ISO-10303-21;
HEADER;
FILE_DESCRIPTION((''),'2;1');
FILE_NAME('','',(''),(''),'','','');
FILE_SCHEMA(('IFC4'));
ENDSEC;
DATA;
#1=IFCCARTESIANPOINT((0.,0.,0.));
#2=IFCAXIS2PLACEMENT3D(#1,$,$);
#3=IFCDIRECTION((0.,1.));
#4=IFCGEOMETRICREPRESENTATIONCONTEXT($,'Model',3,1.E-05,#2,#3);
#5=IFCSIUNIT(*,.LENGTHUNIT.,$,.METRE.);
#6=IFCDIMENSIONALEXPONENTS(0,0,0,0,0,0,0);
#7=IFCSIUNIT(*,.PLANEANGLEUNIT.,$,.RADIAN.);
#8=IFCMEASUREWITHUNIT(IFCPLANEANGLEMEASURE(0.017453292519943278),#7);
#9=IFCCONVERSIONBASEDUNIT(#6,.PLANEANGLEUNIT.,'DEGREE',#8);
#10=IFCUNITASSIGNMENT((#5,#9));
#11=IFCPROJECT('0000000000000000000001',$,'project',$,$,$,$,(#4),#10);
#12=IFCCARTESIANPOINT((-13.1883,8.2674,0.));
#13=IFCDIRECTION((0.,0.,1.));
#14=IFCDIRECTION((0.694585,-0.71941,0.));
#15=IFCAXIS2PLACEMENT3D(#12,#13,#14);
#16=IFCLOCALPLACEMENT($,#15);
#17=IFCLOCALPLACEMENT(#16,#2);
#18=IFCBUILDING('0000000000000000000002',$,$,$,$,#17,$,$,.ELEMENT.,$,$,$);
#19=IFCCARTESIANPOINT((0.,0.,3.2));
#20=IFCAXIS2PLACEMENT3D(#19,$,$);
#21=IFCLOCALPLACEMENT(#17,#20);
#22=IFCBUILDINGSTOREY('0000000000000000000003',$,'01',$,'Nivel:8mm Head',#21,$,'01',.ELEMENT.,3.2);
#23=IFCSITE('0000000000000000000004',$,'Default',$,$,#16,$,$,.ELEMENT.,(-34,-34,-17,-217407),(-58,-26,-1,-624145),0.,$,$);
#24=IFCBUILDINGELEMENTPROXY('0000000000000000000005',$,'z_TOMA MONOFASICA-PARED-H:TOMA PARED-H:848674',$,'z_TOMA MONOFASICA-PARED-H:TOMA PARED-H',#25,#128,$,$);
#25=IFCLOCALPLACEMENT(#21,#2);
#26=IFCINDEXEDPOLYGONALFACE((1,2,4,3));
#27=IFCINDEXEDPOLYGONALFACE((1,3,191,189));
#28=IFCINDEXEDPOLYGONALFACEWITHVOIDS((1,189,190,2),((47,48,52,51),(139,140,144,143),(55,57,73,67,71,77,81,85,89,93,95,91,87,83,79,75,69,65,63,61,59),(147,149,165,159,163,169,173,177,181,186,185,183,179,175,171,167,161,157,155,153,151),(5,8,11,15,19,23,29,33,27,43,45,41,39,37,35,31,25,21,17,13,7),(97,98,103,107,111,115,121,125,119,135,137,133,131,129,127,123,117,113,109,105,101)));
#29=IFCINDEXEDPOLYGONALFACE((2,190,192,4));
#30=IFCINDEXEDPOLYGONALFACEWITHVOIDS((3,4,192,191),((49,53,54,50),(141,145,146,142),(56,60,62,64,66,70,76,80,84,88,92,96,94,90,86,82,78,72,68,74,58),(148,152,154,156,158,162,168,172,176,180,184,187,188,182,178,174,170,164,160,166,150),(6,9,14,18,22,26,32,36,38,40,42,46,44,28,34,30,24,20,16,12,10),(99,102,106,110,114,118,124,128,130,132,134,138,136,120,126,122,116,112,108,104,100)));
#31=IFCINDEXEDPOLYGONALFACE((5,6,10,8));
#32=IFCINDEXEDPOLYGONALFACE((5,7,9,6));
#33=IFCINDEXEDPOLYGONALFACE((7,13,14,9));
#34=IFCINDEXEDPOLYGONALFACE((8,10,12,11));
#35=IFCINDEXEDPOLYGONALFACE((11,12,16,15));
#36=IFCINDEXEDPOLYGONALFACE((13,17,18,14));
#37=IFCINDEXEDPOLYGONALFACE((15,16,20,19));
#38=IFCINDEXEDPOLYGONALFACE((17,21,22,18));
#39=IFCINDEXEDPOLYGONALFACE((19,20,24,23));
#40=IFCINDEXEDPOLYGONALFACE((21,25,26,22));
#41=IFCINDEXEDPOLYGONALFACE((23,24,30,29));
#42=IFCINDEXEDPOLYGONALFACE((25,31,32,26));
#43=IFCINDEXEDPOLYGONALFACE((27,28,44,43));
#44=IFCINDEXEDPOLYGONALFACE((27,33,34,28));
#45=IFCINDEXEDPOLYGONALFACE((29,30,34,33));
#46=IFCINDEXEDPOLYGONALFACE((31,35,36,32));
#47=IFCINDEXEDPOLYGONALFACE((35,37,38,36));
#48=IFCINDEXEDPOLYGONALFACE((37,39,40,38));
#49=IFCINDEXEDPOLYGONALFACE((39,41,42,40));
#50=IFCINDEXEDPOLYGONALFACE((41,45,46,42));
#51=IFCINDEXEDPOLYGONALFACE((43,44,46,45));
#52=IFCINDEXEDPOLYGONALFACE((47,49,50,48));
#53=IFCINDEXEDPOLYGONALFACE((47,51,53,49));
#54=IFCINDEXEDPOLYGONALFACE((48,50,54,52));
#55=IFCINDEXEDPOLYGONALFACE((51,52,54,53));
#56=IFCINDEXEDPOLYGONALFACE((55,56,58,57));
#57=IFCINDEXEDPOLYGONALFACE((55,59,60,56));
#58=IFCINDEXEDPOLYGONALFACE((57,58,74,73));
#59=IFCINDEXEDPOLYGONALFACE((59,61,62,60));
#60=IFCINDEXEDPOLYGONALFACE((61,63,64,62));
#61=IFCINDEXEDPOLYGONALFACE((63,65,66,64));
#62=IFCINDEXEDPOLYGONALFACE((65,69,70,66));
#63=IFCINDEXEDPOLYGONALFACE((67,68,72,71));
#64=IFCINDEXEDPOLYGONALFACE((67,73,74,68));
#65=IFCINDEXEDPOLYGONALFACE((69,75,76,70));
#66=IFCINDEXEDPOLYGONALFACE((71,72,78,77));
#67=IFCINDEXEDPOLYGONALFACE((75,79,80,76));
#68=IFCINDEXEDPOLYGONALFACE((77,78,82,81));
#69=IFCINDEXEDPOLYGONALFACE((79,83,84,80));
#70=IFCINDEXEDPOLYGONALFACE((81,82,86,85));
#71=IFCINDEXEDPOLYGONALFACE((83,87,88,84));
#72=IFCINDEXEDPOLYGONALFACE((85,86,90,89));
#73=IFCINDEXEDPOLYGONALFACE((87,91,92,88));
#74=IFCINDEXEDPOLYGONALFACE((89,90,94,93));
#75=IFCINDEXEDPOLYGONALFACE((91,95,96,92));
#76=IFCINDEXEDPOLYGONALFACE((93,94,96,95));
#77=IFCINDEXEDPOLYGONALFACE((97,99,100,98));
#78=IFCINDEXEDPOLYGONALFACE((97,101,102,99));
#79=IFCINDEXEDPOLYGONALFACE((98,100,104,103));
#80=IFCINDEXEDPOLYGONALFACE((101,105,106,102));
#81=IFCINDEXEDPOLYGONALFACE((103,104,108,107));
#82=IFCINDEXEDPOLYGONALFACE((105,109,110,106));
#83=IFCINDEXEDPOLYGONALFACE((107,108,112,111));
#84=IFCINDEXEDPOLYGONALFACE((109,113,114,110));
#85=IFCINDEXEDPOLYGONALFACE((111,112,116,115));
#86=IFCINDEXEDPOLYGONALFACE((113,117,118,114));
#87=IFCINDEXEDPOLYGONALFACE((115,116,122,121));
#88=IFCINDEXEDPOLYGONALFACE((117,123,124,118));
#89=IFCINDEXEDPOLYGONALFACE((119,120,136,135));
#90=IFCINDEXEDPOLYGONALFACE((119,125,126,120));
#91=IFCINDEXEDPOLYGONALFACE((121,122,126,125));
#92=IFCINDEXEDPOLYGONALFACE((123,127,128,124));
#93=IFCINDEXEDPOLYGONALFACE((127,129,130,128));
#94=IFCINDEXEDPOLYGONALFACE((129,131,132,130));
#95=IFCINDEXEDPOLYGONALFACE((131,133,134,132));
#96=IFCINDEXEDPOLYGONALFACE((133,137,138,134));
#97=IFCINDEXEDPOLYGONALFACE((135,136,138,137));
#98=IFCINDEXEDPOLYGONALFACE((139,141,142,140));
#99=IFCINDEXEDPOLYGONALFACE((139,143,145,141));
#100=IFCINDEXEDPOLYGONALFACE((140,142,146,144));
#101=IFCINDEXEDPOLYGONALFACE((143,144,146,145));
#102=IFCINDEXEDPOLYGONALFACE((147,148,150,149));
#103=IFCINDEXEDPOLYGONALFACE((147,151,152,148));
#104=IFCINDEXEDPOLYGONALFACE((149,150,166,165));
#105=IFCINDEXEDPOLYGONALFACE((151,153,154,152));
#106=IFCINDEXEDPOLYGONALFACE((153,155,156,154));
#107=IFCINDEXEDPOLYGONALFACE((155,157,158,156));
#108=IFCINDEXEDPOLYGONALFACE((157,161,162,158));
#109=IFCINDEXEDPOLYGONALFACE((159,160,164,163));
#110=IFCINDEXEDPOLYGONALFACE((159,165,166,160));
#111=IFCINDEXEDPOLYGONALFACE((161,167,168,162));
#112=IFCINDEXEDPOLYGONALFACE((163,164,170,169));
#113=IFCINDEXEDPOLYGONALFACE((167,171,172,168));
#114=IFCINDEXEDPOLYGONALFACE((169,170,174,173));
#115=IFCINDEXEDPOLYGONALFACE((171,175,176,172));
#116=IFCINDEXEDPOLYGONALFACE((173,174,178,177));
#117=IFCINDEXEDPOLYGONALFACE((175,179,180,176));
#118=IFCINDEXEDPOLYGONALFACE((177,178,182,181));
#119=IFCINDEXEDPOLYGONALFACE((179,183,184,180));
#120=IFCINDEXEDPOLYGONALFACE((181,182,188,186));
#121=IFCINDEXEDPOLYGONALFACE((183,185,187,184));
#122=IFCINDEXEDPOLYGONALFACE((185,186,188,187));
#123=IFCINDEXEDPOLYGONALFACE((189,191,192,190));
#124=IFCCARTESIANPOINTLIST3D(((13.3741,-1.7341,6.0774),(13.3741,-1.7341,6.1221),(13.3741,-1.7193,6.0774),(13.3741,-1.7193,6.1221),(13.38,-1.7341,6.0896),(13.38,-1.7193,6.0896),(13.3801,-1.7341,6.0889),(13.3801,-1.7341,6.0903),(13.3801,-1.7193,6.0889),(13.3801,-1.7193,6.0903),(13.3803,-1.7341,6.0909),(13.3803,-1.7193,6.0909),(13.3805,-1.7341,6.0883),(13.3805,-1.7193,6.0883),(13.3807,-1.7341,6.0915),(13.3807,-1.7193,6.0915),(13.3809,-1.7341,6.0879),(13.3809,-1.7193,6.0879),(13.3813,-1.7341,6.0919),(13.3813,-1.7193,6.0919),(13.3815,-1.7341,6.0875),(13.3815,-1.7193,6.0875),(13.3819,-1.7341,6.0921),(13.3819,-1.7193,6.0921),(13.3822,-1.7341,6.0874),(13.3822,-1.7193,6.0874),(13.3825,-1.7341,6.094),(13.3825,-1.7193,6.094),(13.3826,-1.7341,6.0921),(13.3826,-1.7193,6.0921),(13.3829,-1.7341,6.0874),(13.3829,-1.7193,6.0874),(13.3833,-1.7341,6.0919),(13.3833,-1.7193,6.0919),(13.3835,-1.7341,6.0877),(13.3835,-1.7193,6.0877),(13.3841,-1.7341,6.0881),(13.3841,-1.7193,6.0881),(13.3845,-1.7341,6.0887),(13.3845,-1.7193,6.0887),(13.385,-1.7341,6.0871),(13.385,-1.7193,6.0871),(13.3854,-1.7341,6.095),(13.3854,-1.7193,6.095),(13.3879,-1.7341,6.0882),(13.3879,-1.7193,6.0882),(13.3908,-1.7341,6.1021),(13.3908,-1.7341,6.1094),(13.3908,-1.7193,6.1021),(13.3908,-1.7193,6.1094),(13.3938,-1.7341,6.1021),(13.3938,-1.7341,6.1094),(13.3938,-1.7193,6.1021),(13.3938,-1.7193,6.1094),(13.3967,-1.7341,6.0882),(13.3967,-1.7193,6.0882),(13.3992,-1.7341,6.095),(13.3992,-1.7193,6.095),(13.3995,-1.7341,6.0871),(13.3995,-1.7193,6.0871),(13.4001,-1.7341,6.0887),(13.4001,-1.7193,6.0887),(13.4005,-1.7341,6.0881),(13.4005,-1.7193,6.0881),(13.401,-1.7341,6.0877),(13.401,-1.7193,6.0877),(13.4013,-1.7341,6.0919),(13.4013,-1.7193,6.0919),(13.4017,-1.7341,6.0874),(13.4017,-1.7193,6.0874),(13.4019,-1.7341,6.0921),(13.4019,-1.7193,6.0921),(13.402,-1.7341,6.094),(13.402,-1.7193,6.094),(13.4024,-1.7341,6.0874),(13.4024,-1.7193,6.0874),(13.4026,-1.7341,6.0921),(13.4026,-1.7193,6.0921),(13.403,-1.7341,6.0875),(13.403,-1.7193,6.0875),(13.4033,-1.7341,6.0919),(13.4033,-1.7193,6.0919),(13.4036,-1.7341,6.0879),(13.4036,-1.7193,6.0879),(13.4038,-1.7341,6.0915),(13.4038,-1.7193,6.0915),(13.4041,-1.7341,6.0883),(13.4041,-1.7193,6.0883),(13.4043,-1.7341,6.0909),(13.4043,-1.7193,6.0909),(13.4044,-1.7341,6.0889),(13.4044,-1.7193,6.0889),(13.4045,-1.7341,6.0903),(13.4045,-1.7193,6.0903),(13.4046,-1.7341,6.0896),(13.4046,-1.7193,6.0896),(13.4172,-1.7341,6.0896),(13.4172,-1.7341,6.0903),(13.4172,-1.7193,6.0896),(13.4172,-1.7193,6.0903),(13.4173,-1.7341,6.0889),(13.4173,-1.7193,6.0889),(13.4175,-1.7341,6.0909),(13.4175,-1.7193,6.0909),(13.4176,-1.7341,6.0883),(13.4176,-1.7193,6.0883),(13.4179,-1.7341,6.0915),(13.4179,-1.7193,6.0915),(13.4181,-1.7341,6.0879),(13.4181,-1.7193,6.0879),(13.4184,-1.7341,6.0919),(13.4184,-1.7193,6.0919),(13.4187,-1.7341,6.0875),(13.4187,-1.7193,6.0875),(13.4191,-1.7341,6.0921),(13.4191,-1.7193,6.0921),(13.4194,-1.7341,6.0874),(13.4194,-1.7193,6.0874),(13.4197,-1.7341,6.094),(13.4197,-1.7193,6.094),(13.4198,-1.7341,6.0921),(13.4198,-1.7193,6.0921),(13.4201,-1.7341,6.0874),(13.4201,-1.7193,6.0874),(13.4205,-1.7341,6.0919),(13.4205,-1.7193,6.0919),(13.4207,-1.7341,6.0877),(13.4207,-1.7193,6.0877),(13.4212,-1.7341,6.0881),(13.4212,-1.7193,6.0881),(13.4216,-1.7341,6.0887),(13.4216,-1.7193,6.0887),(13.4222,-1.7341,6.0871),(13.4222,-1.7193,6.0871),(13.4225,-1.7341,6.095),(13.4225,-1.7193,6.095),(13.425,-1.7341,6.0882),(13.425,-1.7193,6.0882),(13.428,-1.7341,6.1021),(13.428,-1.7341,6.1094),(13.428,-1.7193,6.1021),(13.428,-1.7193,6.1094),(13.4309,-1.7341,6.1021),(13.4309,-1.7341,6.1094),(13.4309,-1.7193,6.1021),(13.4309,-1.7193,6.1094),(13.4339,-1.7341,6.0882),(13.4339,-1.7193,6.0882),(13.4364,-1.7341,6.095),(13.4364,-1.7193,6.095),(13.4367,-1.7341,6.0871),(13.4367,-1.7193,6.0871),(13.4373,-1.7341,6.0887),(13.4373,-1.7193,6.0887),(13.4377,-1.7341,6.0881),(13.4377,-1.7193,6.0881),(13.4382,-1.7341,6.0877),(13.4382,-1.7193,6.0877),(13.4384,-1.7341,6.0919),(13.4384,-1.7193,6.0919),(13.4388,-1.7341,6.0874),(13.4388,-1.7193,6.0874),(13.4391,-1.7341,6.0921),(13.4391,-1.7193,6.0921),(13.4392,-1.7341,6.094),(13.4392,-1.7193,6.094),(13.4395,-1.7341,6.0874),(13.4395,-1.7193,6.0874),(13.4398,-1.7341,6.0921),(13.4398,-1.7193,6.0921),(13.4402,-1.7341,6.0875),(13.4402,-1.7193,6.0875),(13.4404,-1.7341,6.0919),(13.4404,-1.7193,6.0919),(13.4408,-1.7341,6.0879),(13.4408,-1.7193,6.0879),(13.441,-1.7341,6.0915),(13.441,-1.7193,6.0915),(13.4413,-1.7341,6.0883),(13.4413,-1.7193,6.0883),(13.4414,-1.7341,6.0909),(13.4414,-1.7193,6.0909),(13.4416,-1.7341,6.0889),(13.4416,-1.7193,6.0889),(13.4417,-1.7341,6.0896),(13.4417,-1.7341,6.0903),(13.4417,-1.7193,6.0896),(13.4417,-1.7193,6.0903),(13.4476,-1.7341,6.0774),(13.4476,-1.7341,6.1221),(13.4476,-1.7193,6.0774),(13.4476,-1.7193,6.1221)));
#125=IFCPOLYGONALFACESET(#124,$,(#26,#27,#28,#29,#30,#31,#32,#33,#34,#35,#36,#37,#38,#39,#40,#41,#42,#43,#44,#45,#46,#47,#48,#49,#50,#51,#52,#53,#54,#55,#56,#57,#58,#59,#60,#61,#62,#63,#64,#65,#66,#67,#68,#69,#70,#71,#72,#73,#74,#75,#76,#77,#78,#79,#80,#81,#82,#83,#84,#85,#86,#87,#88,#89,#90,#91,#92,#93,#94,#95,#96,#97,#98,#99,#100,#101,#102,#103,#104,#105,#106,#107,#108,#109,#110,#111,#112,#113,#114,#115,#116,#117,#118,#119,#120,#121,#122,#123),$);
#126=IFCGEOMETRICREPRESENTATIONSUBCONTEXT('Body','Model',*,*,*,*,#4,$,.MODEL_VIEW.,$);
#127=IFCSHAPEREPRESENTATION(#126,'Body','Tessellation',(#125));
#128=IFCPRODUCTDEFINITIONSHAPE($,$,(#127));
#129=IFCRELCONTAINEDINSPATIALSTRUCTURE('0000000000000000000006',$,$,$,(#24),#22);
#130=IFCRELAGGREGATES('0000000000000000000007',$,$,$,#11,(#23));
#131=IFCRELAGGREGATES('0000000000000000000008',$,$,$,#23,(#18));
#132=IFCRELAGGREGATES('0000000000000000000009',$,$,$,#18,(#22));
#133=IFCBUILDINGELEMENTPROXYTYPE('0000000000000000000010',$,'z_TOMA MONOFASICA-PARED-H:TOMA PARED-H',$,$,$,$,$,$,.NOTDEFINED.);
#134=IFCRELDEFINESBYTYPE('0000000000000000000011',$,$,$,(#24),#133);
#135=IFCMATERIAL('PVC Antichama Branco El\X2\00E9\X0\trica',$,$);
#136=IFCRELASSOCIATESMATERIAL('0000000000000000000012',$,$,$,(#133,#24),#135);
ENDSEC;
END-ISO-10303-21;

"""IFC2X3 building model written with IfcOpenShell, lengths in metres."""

from ifc_helpers import new_model, entity, si_unit, converted_unit, direction, frame, frame_2d, origin, place, context, subcontext, project, spatial, polyline, circle_curve, parameter, trimmed, segment, composite_curve, outline, extrude, source, transform, mapped, material, type_object, type_shapes, element, save


model = new_model("IFC2X3")

# Units and contexts
model_context = context("Model", 3, precision=1e-05, world=origin(), true_north=direction((0.0, 1.0)))
body_context = subcontext(model_context, "Body", "Model", "MODEL_VIEW")
ifc_project = project(units=[si_unit("LENGTHUNIT", "METRE"), converted_unit("PLANEANGLEUNIT", "DEGREE", entity("IfcPlaneAngleMeasure", 0.017453292519943278), si_unit("PLANEANGLEUNIT", "RADIAN"), dimensions=[0, 0, 0, 0, 0, 0, 0])], contexts=[model_context])

# Site, building, storey
site_placement = place(None, frame((-13.1883, 8.2674, 0.0), z_axis=(0.0, 0.0, 1.0), x_axis=(0.694585, -0.71941, 0.0)))
site = spatial("IfcSite", under=ifc_project, at=site_placement, Name="Default", CompositionType="ELEMENT", RefLatitude=(-34, -34, -17, -217407), RefLongitude=(-58, -26, -1, -624145), RefElevation=0.0)
building_placement = place(site_placement, origin())
building = spatial("IfcBuilding", under=site, at=building_placement, CompositionType="ELEMENT")
storey_placement = place(building_placement, frame((0.0, 0.0, 3.2)))
storey = spatial("IfcBuildingStorey", under=building, at=storey_placement, Name="01", ObjectType="Nivel:8mm Head", LongName="01", CompositionType="ELEMENT", Elevation=3.2)

# Building element proxy
ifc_material_1 = material(Name="PVC Antichama Branco Elétrica")
building_element_proxy_type_1 = type_object("IfcBuildingElementProxyType", Name="z_TOMA MONOFASICA-PARED-H:TOMA PARED-H", PredefinedType="NOTDEFINED", material=ifc_material_1)
shared_shape_1 = source(origin(), body_context, "Body", "SweptSolid", [
    extrude(outline(polyline([(-0.0368, -0.0223), (0.0368, -0.0223), (0.0368, 0.0223), (-0.0368, 0.0223), (-0.0368, -0.0223)]), holes=[composite_curve([segment(polyline([(0.0141, 0.0115), (0.0116, 0.0047)]), True, "CONTINUOUS"), segment(polyline([(0.0116, 0.0047), (0.0088, 0.0057)]), True, "CONTINUOUS"), segment(polyline([(0.0088, 0.0057), (0.0096, 0.0078)]), True, "CONTINUOUS"), segment(trimmed(circle_curve(frame_2d((0.0087, 0.0099), x_axis=(1.0, 0.0)), 0.0024), [parameter(27.118901)], [parameter(292.881099)], True, "PARAMETER"), False, "CONTINUOUS"), segment(polyline([(0.0108, 0.011), (0.0113, 0.0126)]), True, "CONTINUOUS"), segment(polyline([(0.0113, 0.0126), (0.0141, 0.0115)]), True, "CONTINUOUS")], self_intersect=False), composite_curve([segment(polyline([(0.0255, 0.0047), (0.023, 0.0115)]), True, "CONTINUOUS"), segment(polyline([(0.023, 0.0115), (0.0258, 0.0126)]), True, "CONTINUOUS"), segment(polyline([(0.0258, 0.0126), (0.0264, 0.011)]), True, "CONTINUOUS"), segment(trimmed(circle_curve(frame_2d((0.0285, 0.0099), x_axis=(1.0, 0.0)), 0.0024), [parameter(247.118901)], [parameter(152.881099)], True, "PARAMETER"), False, "CONTINUOUS"), segment(polyline([(0.0276, 0.0078), (0.0283, 0.0057)]), True, "CONTINUOUS"), segment(polyline([(0.0283, 0.0057), (0.0255, 0.0047)]), True, "CONTINUOUS")], self_intersect=False), polyline([(0.0201, -0.0024), (0.0201, -0.0097), (0.0171, -0.0097), (0.0171, -0.0024), (0.0201, -0.0024)]), composite_curve([segment(polyline([(-0.0141, 0.0115), (-0.0113, 0.0126)]), True, "CONTINUOUS"), segment(polyline([(-0.0113, 0.0126), (-0.0108, 0.011)]), True, "CONTINUOUS"), segment(trimmed(circle_curve(frame_2d((-0.0087, 0.0099), x_axis=(1.0, 0.0)), 0.0024), [parameter(247.118901)], [parameter(152.881099)], True, "PARAMETER"), False, "CONTINUOUS"), segment(polyline([(-0.0096, 0.0078), (-0.0088, 0.0057)]), True, "CONTINUOUS"), segment(polyline([(-0.0088, 0.0057), (-0.0116, 0.0047)]), True, "CONTINUOUS"), segment(polyline([(-0.0116, 0.0047), (-0.0141, 0.0115)]), True, "CONTINUOUS")], self_intersect=False), composite_curve([segment(polyline([(-0.0255, 0.0047), (-0.0283, 0.0057)]), True, "CONTINUOUS"), segment(polyline([(-0.0283, 0.0057), (-0.0276, 0.0078)]), True, "CONTINUOUS"), segment(trimmed(circle_curve(frame_2d((-0.0285, 0.0099), x_axis=(1.0, 0.0)), 0.0024), [parameter(27.118901)], [parameter(292.881099)], True, "PARAMETER"), False, "CONTINUOUS"), segment(polyline([(-0.0264, 0.011), (-0.0258, 0.0126)]), True, "CONTINUOUS"), segment(polyline([(-0.0258, 0.0126), (-0.023, 0.0115)]), True, "CONTINUOUS"), segment(polyline([(-0.023, 0.0115), (-0.0255, 0.0047)]), True, "CONTINUOUS")], self_intersect=False), polyline([(-0.0201, -0.0024), (-0.0171, -0.0024), (-0.0171, -0.0097), (-0.0201, -0.0097), (-0.0201, -0.0024)])]), frame((0.0, -0.005, 0.0223), z_axis=(0.0, 1.0, 0.0), x_axis=(1.0, 0.0, 0.0)), (0.0, 0.0, 1.0), 0.0148),
])
type_shapes(building_element_proxy_type_1, [shared_shape_1])
for number, where, z_axis, x_axis, name in (
    (1, (13.4109, -1.7243, 6.0774), (0.0, 0.0, 1.0), (-1.0, 0.0, 0.0), "z_TOMA MONOFASICA-PARED-H:TOMA PARED-H:848674"),
):
    element("IfcBuildingElementProxy", number, at=place(storey_placement, frame(where, z_axis=z_axis, x_axis=x_axis)), inside=storey, type_object=building_element_proxy_type_1, material=ifc_material_1, Name=name, ObjectType="z_TOMA MONOFASICA-PARED-H:TOMA PARED-H", context=body_context, shape_type="MappedRepresentation", body=[
        mapped(shared_shape_1, transform((0.0, 0.0, 0.0), scale=1.0)),
    ])

save(model, "model.ifc")
